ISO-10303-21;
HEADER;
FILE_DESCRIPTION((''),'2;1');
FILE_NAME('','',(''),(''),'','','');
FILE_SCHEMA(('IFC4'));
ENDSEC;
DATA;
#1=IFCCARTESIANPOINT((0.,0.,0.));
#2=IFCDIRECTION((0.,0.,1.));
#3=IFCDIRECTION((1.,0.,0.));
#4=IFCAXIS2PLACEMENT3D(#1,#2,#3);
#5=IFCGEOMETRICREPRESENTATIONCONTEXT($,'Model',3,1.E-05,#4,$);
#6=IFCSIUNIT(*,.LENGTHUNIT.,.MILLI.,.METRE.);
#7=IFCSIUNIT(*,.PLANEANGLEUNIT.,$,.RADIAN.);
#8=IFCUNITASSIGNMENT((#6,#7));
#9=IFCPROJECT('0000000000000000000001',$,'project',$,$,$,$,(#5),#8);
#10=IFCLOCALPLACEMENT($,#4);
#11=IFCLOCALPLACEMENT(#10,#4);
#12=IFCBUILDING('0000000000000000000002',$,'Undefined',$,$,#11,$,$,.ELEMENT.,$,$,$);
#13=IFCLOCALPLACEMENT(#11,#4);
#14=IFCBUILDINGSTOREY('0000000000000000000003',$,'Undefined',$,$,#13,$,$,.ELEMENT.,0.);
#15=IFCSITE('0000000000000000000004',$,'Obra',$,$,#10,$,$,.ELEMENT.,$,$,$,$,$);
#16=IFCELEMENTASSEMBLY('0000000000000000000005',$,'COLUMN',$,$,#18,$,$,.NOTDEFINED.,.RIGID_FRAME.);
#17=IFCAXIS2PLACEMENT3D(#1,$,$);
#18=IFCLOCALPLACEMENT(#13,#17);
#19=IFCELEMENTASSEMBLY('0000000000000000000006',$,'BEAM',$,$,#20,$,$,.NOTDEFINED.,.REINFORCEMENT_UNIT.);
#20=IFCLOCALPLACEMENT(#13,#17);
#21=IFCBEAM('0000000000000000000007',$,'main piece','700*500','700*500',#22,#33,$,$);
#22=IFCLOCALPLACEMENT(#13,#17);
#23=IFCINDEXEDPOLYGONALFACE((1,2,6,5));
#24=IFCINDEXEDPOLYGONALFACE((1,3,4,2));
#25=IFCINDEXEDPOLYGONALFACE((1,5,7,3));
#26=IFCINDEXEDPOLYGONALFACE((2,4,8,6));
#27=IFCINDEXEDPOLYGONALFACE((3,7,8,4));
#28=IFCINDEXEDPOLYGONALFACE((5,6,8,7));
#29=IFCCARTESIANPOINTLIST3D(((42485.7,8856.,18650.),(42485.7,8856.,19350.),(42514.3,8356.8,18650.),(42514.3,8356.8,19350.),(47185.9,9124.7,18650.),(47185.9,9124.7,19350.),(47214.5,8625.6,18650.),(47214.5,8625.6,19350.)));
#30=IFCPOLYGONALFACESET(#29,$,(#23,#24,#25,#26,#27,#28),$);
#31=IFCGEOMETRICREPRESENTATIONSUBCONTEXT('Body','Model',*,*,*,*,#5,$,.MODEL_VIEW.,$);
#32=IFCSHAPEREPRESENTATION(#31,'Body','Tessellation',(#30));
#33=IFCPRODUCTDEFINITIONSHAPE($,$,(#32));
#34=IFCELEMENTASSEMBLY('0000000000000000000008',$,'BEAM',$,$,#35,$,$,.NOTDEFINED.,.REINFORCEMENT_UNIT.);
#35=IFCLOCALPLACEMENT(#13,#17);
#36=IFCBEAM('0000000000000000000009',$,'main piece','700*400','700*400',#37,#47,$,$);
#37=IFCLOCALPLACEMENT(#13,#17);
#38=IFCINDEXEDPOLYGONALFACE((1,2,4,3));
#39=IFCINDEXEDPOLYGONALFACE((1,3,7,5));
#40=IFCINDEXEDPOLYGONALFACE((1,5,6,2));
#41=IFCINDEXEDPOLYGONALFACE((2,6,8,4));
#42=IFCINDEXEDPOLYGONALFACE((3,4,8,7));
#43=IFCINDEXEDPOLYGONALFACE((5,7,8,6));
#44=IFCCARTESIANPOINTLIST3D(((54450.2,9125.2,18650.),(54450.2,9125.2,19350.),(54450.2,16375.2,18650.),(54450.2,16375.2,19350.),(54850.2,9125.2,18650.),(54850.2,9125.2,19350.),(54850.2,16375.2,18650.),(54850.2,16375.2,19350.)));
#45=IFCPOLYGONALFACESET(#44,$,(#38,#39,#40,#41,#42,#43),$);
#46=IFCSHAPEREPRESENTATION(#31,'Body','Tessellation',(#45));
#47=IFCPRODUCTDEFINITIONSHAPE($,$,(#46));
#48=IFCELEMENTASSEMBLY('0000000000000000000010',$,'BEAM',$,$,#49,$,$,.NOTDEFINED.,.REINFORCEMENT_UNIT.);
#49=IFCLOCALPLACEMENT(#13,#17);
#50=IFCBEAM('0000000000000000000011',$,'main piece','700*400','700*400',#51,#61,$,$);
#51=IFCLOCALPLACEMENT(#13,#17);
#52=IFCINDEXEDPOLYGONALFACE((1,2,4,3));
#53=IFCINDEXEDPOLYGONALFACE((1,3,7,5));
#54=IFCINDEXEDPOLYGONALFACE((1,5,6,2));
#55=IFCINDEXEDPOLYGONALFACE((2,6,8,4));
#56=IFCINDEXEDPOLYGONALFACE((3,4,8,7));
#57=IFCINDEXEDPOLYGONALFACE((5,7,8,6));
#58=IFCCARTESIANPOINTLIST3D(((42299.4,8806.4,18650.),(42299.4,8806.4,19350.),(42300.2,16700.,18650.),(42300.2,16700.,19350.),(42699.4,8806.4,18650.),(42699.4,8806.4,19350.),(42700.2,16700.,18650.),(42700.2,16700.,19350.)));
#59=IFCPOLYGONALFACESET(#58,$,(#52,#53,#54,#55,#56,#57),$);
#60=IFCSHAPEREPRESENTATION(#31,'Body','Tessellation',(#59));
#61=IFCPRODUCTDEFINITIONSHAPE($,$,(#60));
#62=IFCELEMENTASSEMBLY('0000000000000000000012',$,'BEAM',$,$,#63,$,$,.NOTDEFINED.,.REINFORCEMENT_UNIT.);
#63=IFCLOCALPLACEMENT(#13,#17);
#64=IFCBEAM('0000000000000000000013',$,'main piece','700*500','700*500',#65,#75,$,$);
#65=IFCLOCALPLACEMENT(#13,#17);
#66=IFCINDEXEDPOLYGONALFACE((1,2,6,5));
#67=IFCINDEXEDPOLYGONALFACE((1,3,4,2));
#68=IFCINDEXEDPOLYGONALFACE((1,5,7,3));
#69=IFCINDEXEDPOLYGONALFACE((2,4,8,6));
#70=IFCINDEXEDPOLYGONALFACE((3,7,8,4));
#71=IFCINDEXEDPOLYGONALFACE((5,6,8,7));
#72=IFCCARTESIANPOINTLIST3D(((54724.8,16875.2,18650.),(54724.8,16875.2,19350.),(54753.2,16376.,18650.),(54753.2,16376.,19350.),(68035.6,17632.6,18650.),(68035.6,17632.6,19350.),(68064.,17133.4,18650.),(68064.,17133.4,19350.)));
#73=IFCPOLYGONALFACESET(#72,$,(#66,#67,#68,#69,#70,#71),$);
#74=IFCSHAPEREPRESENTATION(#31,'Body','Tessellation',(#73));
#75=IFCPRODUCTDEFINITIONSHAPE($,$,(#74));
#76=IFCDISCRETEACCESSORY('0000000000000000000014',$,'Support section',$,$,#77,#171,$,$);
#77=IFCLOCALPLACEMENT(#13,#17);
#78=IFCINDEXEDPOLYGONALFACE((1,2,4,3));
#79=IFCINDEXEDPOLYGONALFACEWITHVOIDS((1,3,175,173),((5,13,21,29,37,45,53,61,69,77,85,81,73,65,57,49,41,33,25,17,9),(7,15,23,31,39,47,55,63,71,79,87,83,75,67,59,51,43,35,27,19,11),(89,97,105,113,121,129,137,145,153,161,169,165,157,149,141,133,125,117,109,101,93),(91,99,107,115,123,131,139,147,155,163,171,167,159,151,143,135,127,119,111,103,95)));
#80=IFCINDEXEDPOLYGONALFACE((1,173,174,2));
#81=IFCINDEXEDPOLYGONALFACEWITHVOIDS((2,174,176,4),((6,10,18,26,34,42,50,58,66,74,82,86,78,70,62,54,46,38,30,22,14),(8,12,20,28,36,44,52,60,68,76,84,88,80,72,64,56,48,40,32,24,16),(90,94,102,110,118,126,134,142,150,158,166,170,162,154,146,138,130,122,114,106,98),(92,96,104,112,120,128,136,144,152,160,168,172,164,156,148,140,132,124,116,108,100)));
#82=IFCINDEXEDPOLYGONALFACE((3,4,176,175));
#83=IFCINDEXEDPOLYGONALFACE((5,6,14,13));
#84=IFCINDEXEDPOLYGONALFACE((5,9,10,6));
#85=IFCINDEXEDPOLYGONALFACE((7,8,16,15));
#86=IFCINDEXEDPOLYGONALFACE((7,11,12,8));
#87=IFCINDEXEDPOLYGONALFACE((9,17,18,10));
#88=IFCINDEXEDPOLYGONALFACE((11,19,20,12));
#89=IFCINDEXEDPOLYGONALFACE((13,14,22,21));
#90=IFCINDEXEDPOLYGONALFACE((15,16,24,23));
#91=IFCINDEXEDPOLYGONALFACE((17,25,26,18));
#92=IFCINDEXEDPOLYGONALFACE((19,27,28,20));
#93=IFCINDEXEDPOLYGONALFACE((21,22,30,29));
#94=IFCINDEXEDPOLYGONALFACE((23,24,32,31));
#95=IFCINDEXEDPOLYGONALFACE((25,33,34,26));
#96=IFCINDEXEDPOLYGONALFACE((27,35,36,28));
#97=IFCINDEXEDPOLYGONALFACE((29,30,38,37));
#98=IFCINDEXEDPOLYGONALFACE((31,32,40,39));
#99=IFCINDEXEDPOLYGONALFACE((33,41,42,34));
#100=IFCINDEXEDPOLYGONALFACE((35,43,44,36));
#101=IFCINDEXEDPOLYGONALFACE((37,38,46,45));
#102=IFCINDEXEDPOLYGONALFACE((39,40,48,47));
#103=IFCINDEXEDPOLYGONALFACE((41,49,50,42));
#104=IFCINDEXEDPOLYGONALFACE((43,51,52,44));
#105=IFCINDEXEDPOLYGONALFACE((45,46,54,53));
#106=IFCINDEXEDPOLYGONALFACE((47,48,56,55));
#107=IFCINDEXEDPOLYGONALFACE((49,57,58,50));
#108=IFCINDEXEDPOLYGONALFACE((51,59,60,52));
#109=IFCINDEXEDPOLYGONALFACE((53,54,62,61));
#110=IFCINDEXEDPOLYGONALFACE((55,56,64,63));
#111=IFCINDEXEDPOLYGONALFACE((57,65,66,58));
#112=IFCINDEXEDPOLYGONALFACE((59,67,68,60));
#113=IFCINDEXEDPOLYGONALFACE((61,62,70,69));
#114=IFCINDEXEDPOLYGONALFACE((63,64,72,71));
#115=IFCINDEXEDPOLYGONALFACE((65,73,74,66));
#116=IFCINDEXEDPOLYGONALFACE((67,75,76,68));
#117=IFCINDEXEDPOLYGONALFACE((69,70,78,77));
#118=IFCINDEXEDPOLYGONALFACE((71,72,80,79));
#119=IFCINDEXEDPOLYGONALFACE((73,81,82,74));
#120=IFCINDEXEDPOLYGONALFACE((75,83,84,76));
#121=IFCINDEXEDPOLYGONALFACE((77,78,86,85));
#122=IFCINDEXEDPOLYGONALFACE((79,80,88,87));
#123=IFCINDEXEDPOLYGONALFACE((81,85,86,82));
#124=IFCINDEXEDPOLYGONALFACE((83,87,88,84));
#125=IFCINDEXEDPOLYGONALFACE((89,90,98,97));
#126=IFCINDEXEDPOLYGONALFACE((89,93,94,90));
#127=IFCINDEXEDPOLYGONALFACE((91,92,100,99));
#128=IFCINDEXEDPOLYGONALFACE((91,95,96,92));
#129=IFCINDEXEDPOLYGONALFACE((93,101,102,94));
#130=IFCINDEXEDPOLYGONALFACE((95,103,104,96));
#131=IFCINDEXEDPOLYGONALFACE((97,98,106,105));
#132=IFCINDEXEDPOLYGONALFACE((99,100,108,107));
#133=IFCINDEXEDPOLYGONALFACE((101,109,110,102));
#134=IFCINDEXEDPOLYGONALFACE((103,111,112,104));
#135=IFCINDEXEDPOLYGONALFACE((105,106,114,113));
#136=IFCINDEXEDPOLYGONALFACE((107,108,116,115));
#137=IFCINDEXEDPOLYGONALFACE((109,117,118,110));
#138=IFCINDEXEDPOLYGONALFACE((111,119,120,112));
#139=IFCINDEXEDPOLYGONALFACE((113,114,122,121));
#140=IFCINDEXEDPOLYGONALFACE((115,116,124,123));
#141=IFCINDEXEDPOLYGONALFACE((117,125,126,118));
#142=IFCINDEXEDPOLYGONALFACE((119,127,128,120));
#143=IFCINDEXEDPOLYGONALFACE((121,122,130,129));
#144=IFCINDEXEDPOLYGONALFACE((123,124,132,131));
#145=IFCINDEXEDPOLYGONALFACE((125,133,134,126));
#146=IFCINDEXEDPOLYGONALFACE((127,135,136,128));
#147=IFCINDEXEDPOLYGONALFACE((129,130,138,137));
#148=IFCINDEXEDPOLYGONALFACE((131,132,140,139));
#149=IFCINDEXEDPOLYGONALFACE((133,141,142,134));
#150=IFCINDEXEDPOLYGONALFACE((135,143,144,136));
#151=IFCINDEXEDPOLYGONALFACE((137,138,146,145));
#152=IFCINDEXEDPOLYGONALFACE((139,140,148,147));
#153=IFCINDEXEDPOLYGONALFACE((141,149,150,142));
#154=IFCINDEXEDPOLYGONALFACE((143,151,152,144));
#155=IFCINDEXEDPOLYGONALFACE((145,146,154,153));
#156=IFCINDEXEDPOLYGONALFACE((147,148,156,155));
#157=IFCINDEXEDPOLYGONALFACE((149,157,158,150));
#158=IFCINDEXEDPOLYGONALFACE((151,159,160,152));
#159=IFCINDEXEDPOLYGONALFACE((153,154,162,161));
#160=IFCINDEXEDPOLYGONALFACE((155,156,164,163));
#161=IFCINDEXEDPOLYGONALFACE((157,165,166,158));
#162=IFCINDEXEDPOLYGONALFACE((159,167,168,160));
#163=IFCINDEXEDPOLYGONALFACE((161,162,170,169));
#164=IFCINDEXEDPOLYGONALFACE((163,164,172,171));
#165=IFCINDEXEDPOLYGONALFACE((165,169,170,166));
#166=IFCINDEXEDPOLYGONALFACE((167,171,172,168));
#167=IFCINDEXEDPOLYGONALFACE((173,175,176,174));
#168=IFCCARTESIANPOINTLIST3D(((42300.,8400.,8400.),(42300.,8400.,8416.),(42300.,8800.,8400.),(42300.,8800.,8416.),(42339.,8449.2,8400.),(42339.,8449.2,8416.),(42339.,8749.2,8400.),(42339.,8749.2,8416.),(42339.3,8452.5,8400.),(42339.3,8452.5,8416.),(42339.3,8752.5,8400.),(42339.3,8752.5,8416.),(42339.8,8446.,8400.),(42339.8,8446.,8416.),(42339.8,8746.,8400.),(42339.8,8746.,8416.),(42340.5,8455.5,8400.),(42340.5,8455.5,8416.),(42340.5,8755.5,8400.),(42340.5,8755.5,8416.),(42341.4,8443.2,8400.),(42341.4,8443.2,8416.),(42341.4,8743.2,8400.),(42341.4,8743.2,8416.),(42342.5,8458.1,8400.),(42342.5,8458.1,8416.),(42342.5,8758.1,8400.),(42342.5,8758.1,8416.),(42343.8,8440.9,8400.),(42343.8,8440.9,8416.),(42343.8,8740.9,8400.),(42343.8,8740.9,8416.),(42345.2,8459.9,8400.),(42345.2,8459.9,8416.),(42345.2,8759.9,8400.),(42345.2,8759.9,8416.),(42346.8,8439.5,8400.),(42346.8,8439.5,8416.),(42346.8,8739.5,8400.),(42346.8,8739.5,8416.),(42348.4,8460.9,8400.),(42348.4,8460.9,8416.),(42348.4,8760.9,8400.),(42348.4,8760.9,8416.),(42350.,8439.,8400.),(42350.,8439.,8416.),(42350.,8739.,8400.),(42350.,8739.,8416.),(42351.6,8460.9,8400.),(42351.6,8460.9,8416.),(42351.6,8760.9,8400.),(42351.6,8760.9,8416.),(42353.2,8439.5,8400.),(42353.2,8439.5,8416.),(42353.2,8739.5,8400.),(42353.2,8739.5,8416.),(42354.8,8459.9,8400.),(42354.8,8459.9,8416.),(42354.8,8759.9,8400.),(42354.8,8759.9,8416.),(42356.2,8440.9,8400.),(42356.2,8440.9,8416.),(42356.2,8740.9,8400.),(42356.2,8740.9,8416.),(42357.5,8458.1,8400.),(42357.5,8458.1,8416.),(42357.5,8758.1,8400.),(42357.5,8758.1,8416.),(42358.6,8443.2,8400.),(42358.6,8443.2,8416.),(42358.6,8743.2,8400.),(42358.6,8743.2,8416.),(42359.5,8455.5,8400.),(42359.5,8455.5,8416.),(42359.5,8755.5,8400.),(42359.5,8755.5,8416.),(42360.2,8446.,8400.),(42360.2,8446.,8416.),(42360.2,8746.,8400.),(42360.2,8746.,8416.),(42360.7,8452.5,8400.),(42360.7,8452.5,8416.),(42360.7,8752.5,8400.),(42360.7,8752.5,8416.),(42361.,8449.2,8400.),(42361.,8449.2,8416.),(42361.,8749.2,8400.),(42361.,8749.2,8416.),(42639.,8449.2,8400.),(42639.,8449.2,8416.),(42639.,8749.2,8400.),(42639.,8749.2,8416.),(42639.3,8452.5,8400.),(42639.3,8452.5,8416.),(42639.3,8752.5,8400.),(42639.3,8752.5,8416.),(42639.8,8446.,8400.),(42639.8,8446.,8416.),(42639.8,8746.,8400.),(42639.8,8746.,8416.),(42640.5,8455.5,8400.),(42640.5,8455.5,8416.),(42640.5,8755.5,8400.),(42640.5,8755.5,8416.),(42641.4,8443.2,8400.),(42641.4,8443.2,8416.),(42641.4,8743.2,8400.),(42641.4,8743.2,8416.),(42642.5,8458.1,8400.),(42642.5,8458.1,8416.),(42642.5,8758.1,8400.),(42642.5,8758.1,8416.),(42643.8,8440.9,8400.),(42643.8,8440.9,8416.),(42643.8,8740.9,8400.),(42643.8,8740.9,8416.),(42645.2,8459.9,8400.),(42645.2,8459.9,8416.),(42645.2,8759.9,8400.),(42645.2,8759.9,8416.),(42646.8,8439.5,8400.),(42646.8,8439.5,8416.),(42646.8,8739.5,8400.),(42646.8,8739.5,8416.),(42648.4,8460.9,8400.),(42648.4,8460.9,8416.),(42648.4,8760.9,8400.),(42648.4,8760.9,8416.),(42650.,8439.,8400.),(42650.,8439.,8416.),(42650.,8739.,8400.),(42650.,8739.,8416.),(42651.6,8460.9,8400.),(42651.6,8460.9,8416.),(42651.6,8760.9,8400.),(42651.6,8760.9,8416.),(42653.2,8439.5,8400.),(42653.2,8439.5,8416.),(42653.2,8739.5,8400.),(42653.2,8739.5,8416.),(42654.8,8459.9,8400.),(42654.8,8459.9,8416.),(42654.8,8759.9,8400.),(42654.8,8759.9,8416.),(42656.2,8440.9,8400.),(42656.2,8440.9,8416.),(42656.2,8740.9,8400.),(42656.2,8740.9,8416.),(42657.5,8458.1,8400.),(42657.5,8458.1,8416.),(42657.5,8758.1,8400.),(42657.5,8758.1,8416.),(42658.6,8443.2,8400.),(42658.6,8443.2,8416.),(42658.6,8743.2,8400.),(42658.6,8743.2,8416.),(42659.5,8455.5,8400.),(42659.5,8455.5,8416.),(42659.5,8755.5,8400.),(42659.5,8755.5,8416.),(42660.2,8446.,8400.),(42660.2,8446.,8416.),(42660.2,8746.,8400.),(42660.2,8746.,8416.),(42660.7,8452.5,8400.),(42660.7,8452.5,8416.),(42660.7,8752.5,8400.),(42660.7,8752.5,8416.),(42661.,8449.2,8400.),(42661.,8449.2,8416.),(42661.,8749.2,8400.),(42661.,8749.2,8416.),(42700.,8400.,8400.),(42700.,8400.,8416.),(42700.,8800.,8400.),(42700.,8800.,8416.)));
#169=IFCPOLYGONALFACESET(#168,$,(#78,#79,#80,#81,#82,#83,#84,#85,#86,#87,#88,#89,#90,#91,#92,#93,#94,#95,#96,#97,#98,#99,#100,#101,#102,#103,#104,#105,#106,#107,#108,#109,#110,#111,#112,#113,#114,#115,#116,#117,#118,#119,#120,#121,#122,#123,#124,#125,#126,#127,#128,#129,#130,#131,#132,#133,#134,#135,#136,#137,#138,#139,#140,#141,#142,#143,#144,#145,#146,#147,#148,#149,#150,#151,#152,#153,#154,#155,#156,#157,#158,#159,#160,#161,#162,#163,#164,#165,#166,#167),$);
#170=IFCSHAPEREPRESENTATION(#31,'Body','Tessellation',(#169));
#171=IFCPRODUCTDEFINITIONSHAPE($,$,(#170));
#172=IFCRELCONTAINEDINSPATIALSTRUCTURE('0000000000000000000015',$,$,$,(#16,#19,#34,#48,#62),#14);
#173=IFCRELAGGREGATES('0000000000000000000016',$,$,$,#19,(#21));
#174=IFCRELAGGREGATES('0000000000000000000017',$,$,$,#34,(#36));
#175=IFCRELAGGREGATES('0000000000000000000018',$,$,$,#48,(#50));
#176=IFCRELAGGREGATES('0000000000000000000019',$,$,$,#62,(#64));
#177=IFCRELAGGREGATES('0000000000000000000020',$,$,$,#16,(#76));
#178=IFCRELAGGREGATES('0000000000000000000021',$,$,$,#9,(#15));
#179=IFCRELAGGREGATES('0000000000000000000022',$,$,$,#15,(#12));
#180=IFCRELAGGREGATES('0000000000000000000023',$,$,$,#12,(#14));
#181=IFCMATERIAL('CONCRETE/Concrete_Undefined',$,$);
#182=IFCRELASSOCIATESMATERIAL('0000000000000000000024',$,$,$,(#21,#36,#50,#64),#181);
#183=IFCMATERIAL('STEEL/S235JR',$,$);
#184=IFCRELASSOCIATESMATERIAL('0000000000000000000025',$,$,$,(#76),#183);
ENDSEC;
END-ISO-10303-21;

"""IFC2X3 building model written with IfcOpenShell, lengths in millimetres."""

from ifc_helpers import new_model, si_unit, frame, origin_with_axes, origin_2d_with_axis, place, context, subcontext, project, spatial, rectangle, circle, extrude, source, transform, mapped, material, element, aggregate, save


model = new_model("IFC2X3")

# Units and contexts
model_context = context("Model", 3, precision=1e-05, world=origin_with_axes())
body_context = subcontext(model_context, "Body", "Model", "MODEL_VIEW")
ifc_project = project(units=[si_unit("LENGTHUNIT", "METRE", prefix="MILLI"), si_unit("PLANEANGLEUNIT", "RADIAN")], contexts=[model_context])

# Site, building, storey
site_placement = place(None, origin_with_axes())
site = spatial("IfcSite", under=ifc_project, at=site_placement, Name="Obra", CompositionType="ELEMENT")
building_placement = place(site_placement, origin_with_axes())
building = spatial("IfcBuilding", under=site, at=building_placement, Name="Undefined", CompositionType="ELEMENT")
storey_placement = place(building_placement, origin_with_axes())
storey = spatial("IfcBuildingStorey", under=building, at=storey_placement, Name="Undefined", CompositionType="ELEMENT", Elevation=0.0)

# Element assembly
assembly_1_placement = place(storey_placement, origin_with_axes())
assembly_1 = element("IfcElementAssembly", 1, at=assembly_1_placement, inside=storey, Name="COLUMN", AssemblyPlace="NOTDEFINED", PredefinedType="RIGID_FRAME")
ifc_material_1 = material(Name="STEEL/S235JR")
ifc_material_2 = material(Name="CONCRETE/Concrete_Undefined")

# Element assemblies, beams
assembly_2_placement = place(storey_placement, origin_with_axes())
assembly_2 = element("IfcElementAssembly", 2, at=assembly_2_placement, inside=storey, Name="BEAM", AssemblyPlace="NOTDEFINED", PredefinedType="REINFORCEMENT_UNIT")
beam_1_placement = place(assembly_2_placement, frame((47200.2, 8875.2, 19000.0), z_axis=(0.0, 0.0, 1.0), x_axis=(-0.998369, -0.057091, 0.0)))
beam_1 = element("IfcBeam", 3, at=beam_1_placement, material=ifc_material_2, Name="main piece", Description="700*500", ObjectType="700*500", context=body_context, shape_type="SweptSolid", body=[
    extrude(rectangle(XDim=500.0, YDim=700.0, at=origin_2d_with_axis()), frame((4707.9, 0.0, 0.0), z_axis=(-1.0, 0.0, 0.0), x_axis=(0.0, -1.0, 0.0)), (0.0, 0.0, 1.0), 4707.9),
])
aggregate(assembly_2, [beam_1])
assembly_3_placement = place(storey_placement, origin_with_axes())
assembly_3 = element("IfcElementAssembly", 4, at=assembly_3_placement, inside=storey, Name="BEAM", AssemblyPlace="NOTDEFINED", PredefinedType="REINFORCEMENT_UNIT")
beam_2_placement = place(assembly_3_placement, frame((54650.2, 9125.2, 19000.0), z_axis=(0.0, 0.0, 1.0), x_axis=(-0.000002, 1.0, 0.0)))
beam_2 = element("IfcBeam", 5, at=beam_2_placement, material=ifc_material_2, Name="main piece", Description="700*400", ObjectType="700*400", context=body_context, shape_type="SweptSolid", body=[
    extrude(rectangle(XDim=400.0, YDim=700.0, at=origin_2d_with_axis()), frame((7250.0, 0.0, 0.0), z_axis=(-1.0, 0.0, 0.0), x_axis=(0.0, -1.0, 0.0)), (0.0, 0.0, 1.0), 7250.0),
])
aggregate(assembly_3, [beam_2])
assembly_4_placement = place(storey_placement, origin_with_axes())
assembly_4 = element("IfcElementAssembly", 6, at=assembly_4_placement, inside=storey, Name="BEAM", AssemblyPlace="NOTDEFINED", PredefinedType="REINFORCEMENT_UNIT")
beam_3_placement = place(assembly_4_placement, frame((42499.4, 8806.4, 19000.0), z_axis=(0.0, 0.0, 1.0), x_axis=(0.000092, 1.0, 0.0)))
beam_3 = element("IfcBeam", 7, at=beam_3_placement, material=ifc_material_2, Name="main piece", Description="700*400", ObjectType="700*400", context=body_context, shape_type="SweptSolid", body=[
    extrude(rectangle(XDim=400.0, YDim=700.0, at=origin_2d_with_axis()), frame((7893.6, 0.0, 0.0), z_axis=(-1.0, 0.0, 0.0), x_axis=(0.0, -1.0, 0.0)), (0.0, 0.0, 1.0), 7893.6),
])
aggregate(assembly_4, [beam_3])

# Element assembly, beam
assembly_5_placement = place(storey_placement, origin_with_axes())
assembly_5 = element("IfcElementAssembly", 8, at=assembly_5_placement, inside=storey, Name="BEAM", AssemblyPlace="NOTDEFINED", PredefinedType="REINFORCEMENT_UNIT")
beam_4_placement = place(assembly_5_placement, frame((54739.0, 16625.6, 19000.0), z_axis=(0.0, 0.0, 1.0), x_axis=(0.998385, 0.056811, 0.0)))
beam_4 = element("IfcBeam", 9, at=beam_4_placement, material=ifc_material_2, Name="main piece", Description="700*500", ObjectType="700*500", context=body_context, shape_type="SweptSolid", body=[
    extrude(rectangle(XDim=500.0, YDim=700.0, at=origin_2d_with_axis()), frame((13332.3, 0.0, 0.0), z_axis=(-1.0, 0.0, 0.0), x_axis=(0.0, -1.0, 0.0)), (0.0, 0.0, 1.0), 13332.3),
])
aggregate(assembly_5, [beam_4])

# Discrete accessory, opening
discrete_accessory_1_placement = place(assembly_1_placement, frame((42500.0, 8400.0, 8408.0), z_axis=(-1.0, 0.0, 0.0), x_axis=(0.0, 1.0, 0.0)))
discrete_accessory_1 = element("IfcDiscreteAccessory", 10, at=discrete_accessory_1_placement, material=ifc_material_1, Name="Support section", context=body_context, shape_type="SweptSolid", body=[
    extrude(rectangle(XDim=16.0, YDim=400.0, at=origin_2d_with_axis()), frame((400.0, 0.0, 0.0), z_axis=(-1.0, 0.0, 0.0), x_axis=(0.0, -1.0, 0.0)), (0.0, 0.0, 1.0), 400.0),
])
shared_shape_1 = source(origin_with_axes(), body_context, "Body", "SweptSolid", [
    extrude(circle(Radius=11.0, at=origin_2d_with_axis()), frame((0.0, -0.1, 0.0), z_axis=(0.0, 1.0, 0.0), x_axis=(1.0, 0.0, 0.0)), (0.0, 0.0, 1.0), 16.2),
])
opening_1_placement = place(assembly_1_placement, frame((42500.0, 8752.5, 8416.0), z_axis=(1.0, 0.0, 0.0), x_axis=(0.0, -1.0, 0.0)))
element("IfcOpeningElement", 11, at=opening_1_placement, cuts=discrete_accessory_1, ObjectType="Opening", context=body_context, shape_type="MappedRepresentation", body=[
    mapped(shared_shape_1, transform((2.5, 0.0, 150.0))),
    mapped(shared_shape_1, transform((2.5, 0.0, -150.0))),
    mapped(shared_shape_1, transform((302.5, 0.0, 150.0))),
    mapped(shared_shape_1, transform((302.5, 0.0, -150.0))),
])
aggregate(assembly_1, [discrete_accessory_1])

save(model, "model.ifc")
